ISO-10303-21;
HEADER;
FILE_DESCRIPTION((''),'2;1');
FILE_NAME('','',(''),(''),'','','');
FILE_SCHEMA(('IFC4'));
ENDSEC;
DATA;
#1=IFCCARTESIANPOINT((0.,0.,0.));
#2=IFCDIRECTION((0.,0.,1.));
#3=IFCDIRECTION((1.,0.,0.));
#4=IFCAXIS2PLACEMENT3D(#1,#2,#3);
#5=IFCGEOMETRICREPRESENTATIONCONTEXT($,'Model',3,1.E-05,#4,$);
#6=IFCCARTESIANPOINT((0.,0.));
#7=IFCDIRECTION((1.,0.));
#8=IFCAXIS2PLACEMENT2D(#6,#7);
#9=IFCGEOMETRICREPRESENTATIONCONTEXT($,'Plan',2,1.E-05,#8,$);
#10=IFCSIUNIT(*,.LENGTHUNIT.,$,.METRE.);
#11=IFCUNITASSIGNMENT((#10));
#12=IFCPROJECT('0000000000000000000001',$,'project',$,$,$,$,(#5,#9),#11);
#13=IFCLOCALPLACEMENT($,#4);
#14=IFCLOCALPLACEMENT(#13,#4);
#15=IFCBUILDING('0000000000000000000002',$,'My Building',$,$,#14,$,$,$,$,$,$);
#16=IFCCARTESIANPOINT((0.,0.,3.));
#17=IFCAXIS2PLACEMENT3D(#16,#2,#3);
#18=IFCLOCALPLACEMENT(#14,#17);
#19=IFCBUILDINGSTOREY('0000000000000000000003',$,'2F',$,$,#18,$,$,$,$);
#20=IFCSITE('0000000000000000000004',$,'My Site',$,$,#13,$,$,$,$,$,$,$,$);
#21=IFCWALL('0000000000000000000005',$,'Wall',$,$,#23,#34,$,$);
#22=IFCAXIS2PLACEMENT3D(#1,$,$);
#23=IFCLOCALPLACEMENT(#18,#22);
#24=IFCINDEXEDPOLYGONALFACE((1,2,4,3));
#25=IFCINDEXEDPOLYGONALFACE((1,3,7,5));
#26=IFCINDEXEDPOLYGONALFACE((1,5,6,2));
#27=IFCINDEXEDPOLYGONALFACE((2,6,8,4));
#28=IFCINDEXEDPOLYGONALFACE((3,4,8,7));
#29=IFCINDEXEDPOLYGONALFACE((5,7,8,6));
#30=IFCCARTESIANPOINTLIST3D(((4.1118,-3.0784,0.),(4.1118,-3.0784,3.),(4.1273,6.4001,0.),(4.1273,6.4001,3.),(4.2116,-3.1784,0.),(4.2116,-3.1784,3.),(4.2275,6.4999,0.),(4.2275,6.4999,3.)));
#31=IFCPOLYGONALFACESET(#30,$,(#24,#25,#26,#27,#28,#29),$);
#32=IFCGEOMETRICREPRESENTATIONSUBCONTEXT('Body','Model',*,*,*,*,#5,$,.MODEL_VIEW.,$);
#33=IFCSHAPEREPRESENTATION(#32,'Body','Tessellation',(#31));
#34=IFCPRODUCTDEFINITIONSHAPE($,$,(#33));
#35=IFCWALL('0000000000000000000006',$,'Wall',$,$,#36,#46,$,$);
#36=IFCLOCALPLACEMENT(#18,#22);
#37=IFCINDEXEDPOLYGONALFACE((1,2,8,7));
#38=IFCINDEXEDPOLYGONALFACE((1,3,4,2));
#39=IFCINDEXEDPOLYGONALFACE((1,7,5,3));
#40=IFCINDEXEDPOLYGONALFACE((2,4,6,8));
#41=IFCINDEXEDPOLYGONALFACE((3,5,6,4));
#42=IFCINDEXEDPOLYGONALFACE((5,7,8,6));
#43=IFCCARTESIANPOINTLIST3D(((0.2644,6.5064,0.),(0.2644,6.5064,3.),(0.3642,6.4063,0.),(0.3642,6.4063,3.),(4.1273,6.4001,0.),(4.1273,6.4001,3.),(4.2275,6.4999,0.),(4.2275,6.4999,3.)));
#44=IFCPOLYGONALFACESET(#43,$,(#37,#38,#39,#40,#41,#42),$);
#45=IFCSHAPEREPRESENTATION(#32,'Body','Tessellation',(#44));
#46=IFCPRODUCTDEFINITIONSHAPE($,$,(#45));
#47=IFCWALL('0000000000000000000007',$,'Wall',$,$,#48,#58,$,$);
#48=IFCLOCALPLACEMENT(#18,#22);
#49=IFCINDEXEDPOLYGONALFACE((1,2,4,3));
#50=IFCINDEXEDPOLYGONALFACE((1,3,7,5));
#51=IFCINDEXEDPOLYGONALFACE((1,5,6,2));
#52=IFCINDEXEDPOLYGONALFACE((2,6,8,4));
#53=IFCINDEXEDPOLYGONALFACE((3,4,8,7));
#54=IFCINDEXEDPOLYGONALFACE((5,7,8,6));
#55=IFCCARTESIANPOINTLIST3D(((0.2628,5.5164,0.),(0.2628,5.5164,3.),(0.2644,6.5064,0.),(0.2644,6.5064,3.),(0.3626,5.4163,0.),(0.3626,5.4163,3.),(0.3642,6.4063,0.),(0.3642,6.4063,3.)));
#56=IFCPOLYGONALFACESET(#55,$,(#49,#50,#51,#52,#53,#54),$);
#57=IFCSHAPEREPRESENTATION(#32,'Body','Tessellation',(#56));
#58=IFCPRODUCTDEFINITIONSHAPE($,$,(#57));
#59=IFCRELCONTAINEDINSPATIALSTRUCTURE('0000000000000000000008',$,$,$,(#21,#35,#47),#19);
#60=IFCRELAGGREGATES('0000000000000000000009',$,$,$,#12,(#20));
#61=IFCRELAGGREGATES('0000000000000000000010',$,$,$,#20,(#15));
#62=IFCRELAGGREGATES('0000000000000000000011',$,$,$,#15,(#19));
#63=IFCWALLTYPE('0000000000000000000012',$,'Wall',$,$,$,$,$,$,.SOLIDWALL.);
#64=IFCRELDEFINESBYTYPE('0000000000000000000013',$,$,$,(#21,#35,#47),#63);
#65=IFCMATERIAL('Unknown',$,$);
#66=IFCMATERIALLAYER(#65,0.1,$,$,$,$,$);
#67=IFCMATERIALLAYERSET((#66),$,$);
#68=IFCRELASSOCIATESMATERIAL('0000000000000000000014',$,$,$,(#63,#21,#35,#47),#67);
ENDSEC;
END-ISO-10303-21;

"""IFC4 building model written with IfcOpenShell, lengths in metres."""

from ifc_helpers import new_model, si_unit, frame, origin_with_axes, origin_2d_with_axis, place, context, subcontext, project, spatial, line, indexed_curve, outline, extrude, material, layer, layer_set, layer_usage, type_object, element, save


model = new_model("IFC4")

# Units and contexts
model_context = context("Model", 3, precision=1e-05, world=origin_with_axes())
plan_context = context("Plan", 2, precision=1e-05, world=origin_2d_with_axis())
body_context_1 = subcontext(model_context, "Body", "Model", "MODEL_VIEW")
ifc_project = project(units=[si_unit("LENGTHUNIT", "METRE")], contexts=[model_context, plan_context])

# Site, building, storey
site_placement = place(None, origin_with_axes())
site = spatial("IfcSite", under=ifc_project, at=site_placement, Name="My Site")
building_placement = place(site_placement, origin_with_axes())
building = spatial("IfcBuilding", under=site, at=building_placement, Name="My Building")
storey_placement = place(building_placement, frame((0.0, 0.0, 3.0), z_axis=(0.0, 0.0, 1.0), x_axis=(1.0, 0.0, 0.0)))
storey = spatial("IfcBuildingStorey", under=building, at=storey_placement, Name="2F")

# Shared definitions
ifc_material = material(Name="Unknown")

# Shared definitions
ifc_layer_1 = layer(ifc_material, 0.1)
ifc_layer_set_1 = layer_set([ifc_layer_1])
wall_type = type_object("IfcWallType", Name="Wall", PredefinedType="SOLIDWALL", material=ifc_layer_set_1)

# Walls
ifc_layer_usage_1 = layer_usage(ifc_layer_set_1, "AXIS2", "POSITIVE", 0.0)
wall_1_placement = place(storey_placement, frame((4.2116, -3.1784, 0.0), z_axis=(0.0, 0.0, 1.0), x_axis=(0.001639, 0.999999, 0.0)))
element("IfcWall", 1, at=wall_1_placement, inside=storey, type_object=wall_type, material=ifc_layer_usage_1, Name="Wall", context=body_context_1, shape_type="SweptSolid", body=[
    extrude(outline(indexed_curve([(0.0, 0.0), (0.0998, 0.1), (9.5783, 0.1), (9.6783, 0.0)], segments=[line(1, 2, 3, 4, 1)])), origin_with_axes(), (0.0, 0.0, 1.0), 3.0),
])
ifc_layer_usage_2 = layer_usage(ifc_layer_set_1, "AXIS2", "POSITIVE", 0.0)
wall_2_placement = place(storey_placement, frame((4.2275, 6.4999, 0.0), z_axis=(0.0, 0.0, 1.0), x_axis=(-0.999999, 0.001639, 0.0)))
element("IfcWall", 2, at=wall_2_placement, inside=storey, type_object=wall_type, material=ifc_layer_usage_2, Name="Wall", context=body_context_1, shape_type="SweptSolid", body=[
    extrude(outline(indexed_curve([(0.0, 0.0), (0.1, 0.1), (3.8631, 0.1), (3.9631, 0.0)], segments=[line(1, 2, 3, 4, 1)])), origin_with_axes(), (0.0, 0.0, 1.0), 3.0),
])
ifc_layer_usage_3 = layer_usage(ifc_layer_set_1, "AXIS2", "POSITIVE", 0.0)
wall_3_placement = place(storey_placement, frame((0.2644, 6.5064, 0.0), z_axis=(0.0, 0.0, 1.0), x_axis=(-0.001639, -0.999999, 0.0)))
element("IfcWall", 3, at=wall_3_placement, inside=storey, type_object=wall_type, material=ifc_layer_usage_3, Name="Wall", context=body_context_1, shape_type="SweptSolid", body=[
    extrude(outline(indexed_curve([(0.0, 0.0), (0.1, 0.1), (1.09, 0.1), (0.99, 0.0)], segments=[line(1, 2, 3, 4, 1)])), origin_with_axes(), (0.0, 0.0, 1.0), 3.0),
])

save(model, "model.ifc")
